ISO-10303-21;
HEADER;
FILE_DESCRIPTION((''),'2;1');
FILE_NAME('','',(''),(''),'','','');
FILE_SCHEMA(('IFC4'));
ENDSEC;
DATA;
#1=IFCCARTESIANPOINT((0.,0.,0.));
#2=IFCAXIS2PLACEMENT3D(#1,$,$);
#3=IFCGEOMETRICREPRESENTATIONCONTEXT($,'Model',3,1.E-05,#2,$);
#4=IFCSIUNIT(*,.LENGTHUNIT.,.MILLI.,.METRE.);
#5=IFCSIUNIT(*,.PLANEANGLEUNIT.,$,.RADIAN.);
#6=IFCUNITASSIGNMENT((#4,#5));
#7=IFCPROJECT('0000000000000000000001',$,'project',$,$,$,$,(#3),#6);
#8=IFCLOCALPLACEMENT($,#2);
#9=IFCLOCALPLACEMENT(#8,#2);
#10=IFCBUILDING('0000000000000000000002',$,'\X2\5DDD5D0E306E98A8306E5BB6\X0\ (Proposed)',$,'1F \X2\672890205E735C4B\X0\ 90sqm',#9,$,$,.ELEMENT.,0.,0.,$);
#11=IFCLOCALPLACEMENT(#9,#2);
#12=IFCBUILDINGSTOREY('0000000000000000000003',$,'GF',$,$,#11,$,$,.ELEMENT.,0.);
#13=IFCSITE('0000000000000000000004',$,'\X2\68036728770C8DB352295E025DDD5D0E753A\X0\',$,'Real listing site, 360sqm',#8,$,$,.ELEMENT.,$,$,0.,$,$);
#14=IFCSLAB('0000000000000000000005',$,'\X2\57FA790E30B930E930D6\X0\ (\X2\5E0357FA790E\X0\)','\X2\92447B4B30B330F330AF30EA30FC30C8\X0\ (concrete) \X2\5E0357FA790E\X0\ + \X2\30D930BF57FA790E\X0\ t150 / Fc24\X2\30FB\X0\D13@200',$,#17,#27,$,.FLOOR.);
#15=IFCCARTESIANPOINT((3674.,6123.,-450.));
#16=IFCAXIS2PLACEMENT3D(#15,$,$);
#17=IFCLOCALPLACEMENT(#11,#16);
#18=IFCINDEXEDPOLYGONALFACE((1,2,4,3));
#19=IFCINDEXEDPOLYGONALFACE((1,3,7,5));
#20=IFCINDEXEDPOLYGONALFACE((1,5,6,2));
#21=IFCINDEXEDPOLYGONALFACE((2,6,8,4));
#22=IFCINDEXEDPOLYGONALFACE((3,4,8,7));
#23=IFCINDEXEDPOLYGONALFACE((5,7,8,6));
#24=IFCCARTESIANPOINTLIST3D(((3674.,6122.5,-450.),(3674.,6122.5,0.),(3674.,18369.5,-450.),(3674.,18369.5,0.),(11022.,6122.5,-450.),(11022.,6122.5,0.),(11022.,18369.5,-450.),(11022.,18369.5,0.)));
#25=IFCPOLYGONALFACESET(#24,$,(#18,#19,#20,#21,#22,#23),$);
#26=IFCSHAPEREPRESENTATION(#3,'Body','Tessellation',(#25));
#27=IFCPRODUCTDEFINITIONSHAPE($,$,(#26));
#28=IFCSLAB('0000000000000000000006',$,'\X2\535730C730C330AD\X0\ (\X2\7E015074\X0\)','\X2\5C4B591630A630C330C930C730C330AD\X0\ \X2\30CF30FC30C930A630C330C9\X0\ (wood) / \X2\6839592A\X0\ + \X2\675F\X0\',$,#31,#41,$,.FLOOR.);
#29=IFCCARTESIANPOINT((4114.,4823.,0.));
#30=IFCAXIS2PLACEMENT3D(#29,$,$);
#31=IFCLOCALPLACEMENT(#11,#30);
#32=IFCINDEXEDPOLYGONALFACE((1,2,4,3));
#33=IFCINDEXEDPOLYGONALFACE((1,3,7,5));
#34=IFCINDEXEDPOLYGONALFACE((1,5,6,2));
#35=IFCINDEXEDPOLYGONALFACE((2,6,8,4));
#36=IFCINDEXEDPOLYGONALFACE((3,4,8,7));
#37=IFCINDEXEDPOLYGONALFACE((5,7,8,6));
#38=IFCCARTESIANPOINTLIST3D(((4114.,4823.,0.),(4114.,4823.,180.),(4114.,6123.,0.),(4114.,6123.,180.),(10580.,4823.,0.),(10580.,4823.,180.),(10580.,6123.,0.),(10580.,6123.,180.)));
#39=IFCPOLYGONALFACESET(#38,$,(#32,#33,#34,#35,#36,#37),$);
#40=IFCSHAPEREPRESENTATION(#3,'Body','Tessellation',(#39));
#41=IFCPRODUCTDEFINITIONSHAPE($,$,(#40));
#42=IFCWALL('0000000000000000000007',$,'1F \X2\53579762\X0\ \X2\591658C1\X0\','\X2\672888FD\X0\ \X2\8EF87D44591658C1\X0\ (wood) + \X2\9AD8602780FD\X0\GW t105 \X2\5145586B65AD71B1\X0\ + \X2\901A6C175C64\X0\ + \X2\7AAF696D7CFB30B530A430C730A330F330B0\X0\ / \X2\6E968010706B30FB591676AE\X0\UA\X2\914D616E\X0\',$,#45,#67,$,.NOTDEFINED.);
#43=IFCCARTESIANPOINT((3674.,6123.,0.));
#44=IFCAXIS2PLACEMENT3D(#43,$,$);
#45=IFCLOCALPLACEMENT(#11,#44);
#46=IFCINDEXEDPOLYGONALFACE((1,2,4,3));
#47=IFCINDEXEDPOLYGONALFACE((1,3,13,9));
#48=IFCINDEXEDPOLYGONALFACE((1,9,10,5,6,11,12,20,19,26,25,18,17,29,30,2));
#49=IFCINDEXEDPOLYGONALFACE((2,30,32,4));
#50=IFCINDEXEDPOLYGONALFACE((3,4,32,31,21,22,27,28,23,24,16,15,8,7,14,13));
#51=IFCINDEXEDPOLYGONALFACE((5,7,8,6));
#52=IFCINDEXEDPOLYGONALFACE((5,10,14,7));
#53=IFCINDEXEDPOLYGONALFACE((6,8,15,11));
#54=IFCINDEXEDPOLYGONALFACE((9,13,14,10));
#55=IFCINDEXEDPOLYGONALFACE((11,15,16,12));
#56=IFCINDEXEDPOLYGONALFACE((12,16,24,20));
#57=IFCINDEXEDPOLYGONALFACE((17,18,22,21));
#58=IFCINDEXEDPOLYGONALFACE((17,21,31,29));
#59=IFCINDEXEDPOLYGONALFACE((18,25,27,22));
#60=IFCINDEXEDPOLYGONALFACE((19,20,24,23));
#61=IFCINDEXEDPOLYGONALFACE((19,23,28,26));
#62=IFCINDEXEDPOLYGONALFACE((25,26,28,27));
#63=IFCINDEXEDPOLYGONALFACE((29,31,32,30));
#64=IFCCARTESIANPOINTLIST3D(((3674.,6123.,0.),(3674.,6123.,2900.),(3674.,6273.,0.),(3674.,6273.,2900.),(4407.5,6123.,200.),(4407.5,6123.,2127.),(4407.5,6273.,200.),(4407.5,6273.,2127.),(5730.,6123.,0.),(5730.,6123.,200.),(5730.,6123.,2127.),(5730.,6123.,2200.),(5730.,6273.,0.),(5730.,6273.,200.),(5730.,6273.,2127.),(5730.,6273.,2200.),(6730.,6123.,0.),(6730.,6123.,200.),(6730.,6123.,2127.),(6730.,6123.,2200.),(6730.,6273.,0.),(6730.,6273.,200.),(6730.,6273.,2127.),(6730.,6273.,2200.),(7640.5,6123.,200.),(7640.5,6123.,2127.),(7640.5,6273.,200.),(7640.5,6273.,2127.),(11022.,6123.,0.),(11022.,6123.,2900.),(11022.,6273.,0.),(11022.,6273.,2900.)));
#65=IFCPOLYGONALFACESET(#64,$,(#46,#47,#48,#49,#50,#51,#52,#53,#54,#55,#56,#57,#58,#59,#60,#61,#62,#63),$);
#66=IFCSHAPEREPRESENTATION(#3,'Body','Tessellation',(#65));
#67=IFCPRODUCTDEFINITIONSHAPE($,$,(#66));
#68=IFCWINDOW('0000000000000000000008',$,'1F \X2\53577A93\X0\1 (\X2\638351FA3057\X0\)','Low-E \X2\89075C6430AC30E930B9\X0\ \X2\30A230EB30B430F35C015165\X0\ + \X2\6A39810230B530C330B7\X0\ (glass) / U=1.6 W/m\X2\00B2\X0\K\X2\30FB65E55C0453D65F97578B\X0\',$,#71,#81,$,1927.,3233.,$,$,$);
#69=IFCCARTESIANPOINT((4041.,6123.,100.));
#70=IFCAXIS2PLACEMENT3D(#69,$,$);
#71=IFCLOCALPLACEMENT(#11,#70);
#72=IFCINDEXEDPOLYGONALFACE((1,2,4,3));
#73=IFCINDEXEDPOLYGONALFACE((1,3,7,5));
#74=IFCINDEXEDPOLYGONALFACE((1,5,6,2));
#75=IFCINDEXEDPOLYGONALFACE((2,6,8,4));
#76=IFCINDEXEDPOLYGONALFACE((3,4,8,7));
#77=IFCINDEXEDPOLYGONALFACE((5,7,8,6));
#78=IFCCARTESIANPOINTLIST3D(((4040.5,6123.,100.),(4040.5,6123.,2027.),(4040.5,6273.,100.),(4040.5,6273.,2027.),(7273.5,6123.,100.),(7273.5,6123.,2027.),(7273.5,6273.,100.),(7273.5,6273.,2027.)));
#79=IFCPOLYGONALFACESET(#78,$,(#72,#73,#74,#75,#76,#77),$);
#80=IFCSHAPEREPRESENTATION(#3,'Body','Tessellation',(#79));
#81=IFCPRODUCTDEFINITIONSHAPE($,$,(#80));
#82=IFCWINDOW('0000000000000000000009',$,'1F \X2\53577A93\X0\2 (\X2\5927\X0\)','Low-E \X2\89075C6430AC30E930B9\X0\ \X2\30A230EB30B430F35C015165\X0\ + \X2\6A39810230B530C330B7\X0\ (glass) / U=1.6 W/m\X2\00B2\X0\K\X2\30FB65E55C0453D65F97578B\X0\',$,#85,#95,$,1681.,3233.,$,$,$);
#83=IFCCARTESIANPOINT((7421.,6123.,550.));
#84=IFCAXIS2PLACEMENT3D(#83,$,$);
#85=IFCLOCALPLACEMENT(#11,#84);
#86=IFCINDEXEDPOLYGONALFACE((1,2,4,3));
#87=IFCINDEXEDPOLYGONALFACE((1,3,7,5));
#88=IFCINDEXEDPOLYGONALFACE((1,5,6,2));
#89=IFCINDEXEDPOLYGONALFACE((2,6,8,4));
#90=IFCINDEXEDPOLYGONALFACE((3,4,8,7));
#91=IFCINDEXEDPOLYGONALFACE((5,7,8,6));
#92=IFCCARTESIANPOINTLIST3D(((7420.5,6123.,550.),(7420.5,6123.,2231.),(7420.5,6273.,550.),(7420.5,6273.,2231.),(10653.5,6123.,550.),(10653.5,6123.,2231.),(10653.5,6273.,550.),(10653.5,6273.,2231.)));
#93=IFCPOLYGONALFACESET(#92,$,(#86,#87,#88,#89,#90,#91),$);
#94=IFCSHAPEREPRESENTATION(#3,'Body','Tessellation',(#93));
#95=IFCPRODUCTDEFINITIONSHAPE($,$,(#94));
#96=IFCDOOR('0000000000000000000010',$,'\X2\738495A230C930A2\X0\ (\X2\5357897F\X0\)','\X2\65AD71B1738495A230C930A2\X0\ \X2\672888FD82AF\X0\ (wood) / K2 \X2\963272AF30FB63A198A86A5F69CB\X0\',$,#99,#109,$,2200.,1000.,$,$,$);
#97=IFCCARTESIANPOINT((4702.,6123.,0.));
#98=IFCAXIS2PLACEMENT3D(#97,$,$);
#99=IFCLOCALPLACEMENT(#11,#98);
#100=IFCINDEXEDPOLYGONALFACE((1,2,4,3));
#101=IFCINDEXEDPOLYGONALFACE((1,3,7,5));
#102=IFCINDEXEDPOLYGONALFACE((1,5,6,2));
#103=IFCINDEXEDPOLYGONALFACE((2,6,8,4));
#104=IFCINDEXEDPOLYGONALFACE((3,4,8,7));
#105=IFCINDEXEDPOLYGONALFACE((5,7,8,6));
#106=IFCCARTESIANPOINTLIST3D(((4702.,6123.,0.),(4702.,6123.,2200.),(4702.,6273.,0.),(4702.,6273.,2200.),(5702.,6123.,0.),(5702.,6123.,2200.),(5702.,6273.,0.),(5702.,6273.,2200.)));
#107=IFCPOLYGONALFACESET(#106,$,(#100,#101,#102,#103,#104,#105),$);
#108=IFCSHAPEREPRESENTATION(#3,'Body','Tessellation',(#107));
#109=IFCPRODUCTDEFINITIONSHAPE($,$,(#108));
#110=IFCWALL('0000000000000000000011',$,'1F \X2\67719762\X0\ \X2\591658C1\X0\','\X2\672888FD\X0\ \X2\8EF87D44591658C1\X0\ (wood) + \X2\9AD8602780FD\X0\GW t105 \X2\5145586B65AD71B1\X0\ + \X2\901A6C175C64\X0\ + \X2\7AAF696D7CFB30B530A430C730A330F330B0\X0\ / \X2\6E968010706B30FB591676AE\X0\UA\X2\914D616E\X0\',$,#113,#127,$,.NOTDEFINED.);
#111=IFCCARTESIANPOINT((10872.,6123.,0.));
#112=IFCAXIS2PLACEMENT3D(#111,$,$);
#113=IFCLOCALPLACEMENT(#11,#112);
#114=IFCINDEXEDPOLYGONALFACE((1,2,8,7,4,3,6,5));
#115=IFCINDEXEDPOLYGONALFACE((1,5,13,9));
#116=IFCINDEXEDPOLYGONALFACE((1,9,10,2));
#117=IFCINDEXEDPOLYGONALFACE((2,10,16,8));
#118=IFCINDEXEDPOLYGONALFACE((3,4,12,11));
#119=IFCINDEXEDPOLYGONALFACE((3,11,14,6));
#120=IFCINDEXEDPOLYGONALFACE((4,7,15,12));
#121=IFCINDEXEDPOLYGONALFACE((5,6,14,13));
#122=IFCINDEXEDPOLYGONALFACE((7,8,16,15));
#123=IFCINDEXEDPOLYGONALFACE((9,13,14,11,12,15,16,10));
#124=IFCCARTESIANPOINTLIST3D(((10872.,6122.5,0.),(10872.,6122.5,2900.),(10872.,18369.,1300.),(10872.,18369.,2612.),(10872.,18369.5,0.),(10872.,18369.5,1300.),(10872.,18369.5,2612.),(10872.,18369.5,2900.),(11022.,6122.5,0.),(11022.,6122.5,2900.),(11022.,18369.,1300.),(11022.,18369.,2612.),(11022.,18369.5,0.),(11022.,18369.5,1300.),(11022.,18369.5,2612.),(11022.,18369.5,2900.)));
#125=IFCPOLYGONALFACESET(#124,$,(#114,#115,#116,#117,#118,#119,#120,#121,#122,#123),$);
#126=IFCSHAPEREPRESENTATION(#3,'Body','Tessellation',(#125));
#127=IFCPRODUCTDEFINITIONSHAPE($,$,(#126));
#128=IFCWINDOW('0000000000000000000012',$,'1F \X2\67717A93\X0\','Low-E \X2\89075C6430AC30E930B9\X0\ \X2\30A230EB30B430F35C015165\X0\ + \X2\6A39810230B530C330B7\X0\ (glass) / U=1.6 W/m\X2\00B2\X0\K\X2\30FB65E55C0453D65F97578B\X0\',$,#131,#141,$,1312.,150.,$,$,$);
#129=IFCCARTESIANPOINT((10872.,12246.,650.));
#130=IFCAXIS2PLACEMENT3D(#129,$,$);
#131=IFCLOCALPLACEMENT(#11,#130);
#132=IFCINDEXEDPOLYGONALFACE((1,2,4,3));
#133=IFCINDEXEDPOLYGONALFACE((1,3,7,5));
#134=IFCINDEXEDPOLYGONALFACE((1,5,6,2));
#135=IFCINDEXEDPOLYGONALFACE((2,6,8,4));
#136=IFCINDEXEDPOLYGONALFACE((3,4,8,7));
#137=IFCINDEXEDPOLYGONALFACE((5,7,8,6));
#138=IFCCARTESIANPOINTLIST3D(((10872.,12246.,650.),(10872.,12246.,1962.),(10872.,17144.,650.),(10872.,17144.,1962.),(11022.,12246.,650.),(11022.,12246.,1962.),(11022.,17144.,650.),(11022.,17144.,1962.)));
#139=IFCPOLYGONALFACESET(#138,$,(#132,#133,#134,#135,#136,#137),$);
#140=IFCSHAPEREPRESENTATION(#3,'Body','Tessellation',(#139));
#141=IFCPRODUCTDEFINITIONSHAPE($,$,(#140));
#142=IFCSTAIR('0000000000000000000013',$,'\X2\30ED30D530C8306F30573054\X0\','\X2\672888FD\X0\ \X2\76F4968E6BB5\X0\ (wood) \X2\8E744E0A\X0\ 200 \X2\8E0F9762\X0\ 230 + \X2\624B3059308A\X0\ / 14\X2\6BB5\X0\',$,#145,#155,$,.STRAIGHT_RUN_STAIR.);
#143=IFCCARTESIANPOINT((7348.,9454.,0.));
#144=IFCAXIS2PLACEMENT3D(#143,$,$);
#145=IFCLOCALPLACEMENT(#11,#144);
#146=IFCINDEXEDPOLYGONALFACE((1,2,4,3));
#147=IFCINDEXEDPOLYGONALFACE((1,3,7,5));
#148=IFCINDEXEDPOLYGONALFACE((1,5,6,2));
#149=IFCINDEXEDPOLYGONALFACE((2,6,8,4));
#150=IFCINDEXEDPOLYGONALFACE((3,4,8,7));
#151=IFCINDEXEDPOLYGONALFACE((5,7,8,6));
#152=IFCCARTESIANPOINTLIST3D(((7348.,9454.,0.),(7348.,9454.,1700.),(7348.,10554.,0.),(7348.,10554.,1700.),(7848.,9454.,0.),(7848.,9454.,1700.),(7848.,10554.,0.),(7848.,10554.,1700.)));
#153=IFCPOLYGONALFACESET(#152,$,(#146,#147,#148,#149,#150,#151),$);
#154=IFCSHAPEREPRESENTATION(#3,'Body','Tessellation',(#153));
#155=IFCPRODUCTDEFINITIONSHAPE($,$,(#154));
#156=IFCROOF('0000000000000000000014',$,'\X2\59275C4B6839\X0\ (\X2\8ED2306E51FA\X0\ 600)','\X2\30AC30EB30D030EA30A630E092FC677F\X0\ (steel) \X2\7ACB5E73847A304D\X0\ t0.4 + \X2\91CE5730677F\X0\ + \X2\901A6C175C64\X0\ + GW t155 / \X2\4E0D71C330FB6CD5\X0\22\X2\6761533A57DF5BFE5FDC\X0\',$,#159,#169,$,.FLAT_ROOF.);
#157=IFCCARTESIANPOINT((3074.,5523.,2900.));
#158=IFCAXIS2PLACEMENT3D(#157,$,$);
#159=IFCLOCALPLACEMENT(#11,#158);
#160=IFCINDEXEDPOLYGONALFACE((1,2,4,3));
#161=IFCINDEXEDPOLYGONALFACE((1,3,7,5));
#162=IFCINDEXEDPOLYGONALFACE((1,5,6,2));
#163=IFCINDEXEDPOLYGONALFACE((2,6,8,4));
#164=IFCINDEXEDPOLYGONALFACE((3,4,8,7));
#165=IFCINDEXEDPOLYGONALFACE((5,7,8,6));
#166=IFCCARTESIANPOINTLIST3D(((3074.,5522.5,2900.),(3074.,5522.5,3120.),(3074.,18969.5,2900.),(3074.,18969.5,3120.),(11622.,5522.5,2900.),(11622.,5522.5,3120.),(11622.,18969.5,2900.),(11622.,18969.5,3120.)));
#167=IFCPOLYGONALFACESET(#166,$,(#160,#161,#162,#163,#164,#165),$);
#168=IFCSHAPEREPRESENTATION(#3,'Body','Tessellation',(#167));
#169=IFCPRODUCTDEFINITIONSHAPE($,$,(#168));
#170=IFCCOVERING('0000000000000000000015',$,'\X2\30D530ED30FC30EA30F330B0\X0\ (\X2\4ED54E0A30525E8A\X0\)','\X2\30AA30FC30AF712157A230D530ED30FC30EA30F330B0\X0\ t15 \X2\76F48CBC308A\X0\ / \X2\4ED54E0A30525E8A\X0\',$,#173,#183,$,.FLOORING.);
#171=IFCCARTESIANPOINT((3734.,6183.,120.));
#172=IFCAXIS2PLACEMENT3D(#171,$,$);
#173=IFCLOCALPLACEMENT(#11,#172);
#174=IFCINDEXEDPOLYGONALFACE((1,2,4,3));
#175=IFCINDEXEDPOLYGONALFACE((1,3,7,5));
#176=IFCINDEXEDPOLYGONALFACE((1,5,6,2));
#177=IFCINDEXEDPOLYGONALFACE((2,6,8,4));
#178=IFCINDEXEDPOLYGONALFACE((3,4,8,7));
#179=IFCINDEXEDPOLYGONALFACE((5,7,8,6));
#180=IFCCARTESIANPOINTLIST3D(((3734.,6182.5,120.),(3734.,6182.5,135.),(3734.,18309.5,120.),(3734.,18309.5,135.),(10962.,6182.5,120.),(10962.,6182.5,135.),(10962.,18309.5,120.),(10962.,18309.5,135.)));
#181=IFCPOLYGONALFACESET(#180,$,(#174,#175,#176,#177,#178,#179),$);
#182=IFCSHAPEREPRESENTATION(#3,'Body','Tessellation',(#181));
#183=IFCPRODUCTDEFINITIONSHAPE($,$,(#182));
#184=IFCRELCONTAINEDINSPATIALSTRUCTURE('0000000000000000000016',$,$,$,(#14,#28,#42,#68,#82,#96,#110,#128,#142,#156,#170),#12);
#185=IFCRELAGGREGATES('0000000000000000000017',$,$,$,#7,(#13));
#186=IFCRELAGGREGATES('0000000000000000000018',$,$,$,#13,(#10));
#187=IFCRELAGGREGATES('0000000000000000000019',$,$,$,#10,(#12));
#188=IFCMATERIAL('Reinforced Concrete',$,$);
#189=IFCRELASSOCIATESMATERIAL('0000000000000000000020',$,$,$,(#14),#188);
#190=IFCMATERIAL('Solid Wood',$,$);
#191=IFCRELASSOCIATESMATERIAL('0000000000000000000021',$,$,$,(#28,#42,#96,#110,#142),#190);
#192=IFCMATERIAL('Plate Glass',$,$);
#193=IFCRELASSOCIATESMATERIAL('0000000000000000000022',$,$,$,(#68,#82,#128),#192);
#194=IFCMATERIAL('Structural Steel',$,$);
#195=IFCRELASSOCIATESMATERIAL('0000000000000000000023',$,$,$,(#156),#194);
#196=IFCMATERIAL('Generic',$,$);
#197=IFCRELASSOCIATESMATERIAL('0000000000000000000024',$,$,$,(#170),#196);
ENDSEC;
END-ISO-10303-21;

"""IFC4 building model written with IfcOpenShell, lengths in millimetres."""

from ifc_helpers import new_model, si_unit, frame, frame_2d, origin, place, context, project, spatial, rectangle, extrude, material, element, fill, save


model = new_model("IFC4")

# Units and contexts
model_context = context("Model", 3, precision=1e-05, world=origin())
ifc_project = project(units=[si_unit("LENGTHUNIT", "METRE", prefix="MILLI"), si_unit("PLANEANGLEUNIT", "RADIAN")], contexts=[model_context])

# Site, building, storey
site_placement = place(None, origin())
site = spatial("IfcSite", under=ifc_project, at=site_placement, Name="栃木県足利市川崎町", ObjectType="Real listing site, 360sqm", CompositionType="ELEMENT", RefElevation=0.0)
building_placement = place(site_placement, origin())
building = spatial("IfcBuilding", under=site, at=building_placement, Name="川崎の風の家 (Proposed)", ObjectType="1F 木造平屋 90sqm", CompositionType="ELEMENT", ElevationOfRefHeight=0.0, ElevationOfTerrain=0.0)
storey_placement = place(building_placement, origin())
storey = spatial("IfcBuildingStorey", under=building, at=storey_placement, Name="GF", CompositionType="ELEMENT", Elevation=0.0)

# Slabs
ifc_material_1 = material(Name="Reinforced Concrete")
slab_1_placement = place(storey_placement, frame((3674.0, 6123.0, -450.0)))
element("IfcSlab", 1, at=slab_1_placement, inside=storey, material=ifc_material_1, Name="基礎スラブ (布基礎)", Description="鉄筋コンクリート (concrete) 布基礎 + ベタ基礎 t150 / Fc24・D13@200", PredefinedType="FLOOR", context=model_context, shape_type="SweptSolid", body=[
    extrude(rectangle(XDim=7348.0, YDim=12247.0, at=frame_2d((3674.0, 6123.0))), frame((3674.0, 6123.0, -450.0)), (0.0, 0.0, 1.0), 450.0),
])
ifc_material_2 = material(Name="Solid Wood")
slab_2_placement = place(storey_placement, frame((4114.0, 4823.0, 0.0)))
element("IfcSlab", 2, at=slab_2_placement, inside=storey, material=ifc_material_2, Name="南デッキ (縁側)", Description="屋外ウッドデッキ ハードウッド (wood) / 根太 + 束", PredefinedType="FLOOR", context=model_context, shape_type="SweptSolid", body=[
    extrude(rectangle(XDim=6466.0, YDim=1300.0, at=frame_2d((3233.0, 650.0))), frame((4114.0, 4823.0, 0.0)), (0.0, 0.0, 1.0), 180.0),
])

# Wall, openings, windows, door
wall_1_placement = place(storey_placement, frame((3674.0, 6123.0, 0.0)))
wall_1 = element("IfcWall", 3, at=wall_1_placement, inside=storey, material=ifc_material_2, Name="1F 南面 外壁", Description="木製 軸組外壁 (wood) + 高性能GW t105 充填断熱 + 通気層 + 窯業系サイディング / 準耐火・外皮UA配慮", PredefinedType="NOTDEFINED", context=model_context, shape_type="SweptSolid", body=[
    extrude(rectangle(XDim=7348.0, YDim=150.0, at=frame_2d((3674.0, 75.0))), frame((3674.0, 6123.0, 0.0)), (0.0, 0.0, 1.0), 2900.0),
])
opening_1_placement = place(storey_placement, frame((4041.0, 6123.0, 100.0)))
opening_1 = element("IfcOpeningElement", 4, at=opening_1_placement, cuts=wall_1, PredefinedType="NOTDEFINED", context=model_context, shape_type="SweptSolid", body=[
    extrude(rectangle(XDim=3233.0, YDim=150.0, at=frame_2d((1616.0, 75.0))), frame((4041.0, 6123.0, 100.0)), (0.0, 0.0, 1.0), 1927.0),
])
opening_2_placement = place(storey_placement, frame((7421.0, 6123.0, 550.0)))
opening_2 = element("IfcOpeningElement", 5, at=opening_2_placement, cuts=wall_1, PredefinedType="NOTDEFINED", context=model_context, shape_type="SweptSolid", body=[
    extrude(rectangle(XDim=3233.0, YDim=150.0, at=frame_2d((1616.0, 75.0))), frame((7421.0, 6123.0, 550.0)), (0.0, 0.0, 1.0), 1681.0),
])
opening_3_placement = place(storey_placement, frame((4702.0, 6123.0, 0.0)))
opening_3 = element("IfcOpeningElement", 6, at=opening_3_placement, cuts=wall_1, PredefinedType="NOTDEFINED", context=model_context, shape_type="SweptSolid", body=[
    extrude(rectangle(XDim=1000.0, YDim=150.0, at=frame_2d((500.0, 75.0))), frame((4702.0, 6123.0, 0.0)), (0.0, 0.0, 1.0), 2200.0),
])
ifc_material_3 = material(Name="Plate Glass")
window_1_placement = place(storey_placement, frame((4041.0, 6123.0, 100.0)))
window_1 = element("IfcWindow", 7, at=window_1_placement, inside=storey, material=ifc_material_3, Name="1F 南窓1 (掃出し)", Description="Low-E 複層ガラス アルゴン封入 + 樹脂サッシ (glass) / U=1.6 W/m²K・日射取得型", OverallHeight=1927.0, OverallWidth=3233.0, context=model_context, shape_type="SweptSolid", body=[
    extrude(rectangle(XDim=3233.0, YDim=150.0, at=frame_2d((1616.0, 75.0))), frame((4041.0, 6123.0, 100.0)), (0.0, 0.0, 1.0), 1927.0),
])
fill(opening_1, window_1)
window_2_placement = place(storey_placement, frame((7421.0, 6123.0, 550.0)))
window_2 = element("IfcWindow", 8, at=window_2_placement, inside=storey, material=ifc_material_3, Name="1F 南窓2 (大)", Description="Low-E 複層ガラス アルゴン封入 + 樹脂サッシ (glass) / U=1.6 W/m²K・日射取得型", OverallHeight=1681.0, OverallWidth=3233.0, context=model_context, shape_type="SweptSolid", body=[
    extrude(rectangle(XDim=3233.0, YDim=150.0, at=frame_2d((1616.0, 75.0))), frame((7421.0, 6123.0, 550.0)), (0.0, 0.0, 1.0), 1681.0),
])
fill(opening_2, window_2)
door_placement = place(storey_placement, frame((4702.0, 6123.0, 0.0)))
door = element("IfcDoor", 9, at=door_placement, inside=storey, material=ifc_material_2, Name="玄関ドア (南西)", Description="断熱玄関ドア 木製芯 (wood) / K2 防犯・採風機構", OverallHeight=2200.0, OverallWidth=1000.0, context=model_context, shape_type="SweptSolid", body=[
    extrude(rectangle(XDim=1000.0, YDim=150.0, at=frame_2d((500.0, 75.0))), frame((4702.0, 6123.0, 0.0)), (0.0, 0.0, 1.0), 2200.0),
])
fill(opening_3, door)

# Wall, opening, window
wall_2_placement = place(storey_placement, frame((10872.0, 6123.0, 0.0)))
wall_2 = element("IfcWall", 10, at=wall_2_placement, inside=storey, material=ifc_material_2, Name="1F 東面 外壁", Description="木製 軸組外壁 (wood) + 高性能GW t105 充填断熱 + 通気層 + 窯業系サイディング / 準耐火・外皮UA配慮", PredefinedType="NOTDEFINED", context=model_context, shape_type="SweptSolid", body=[
    extrude(rectangle(XDim=150.0, YDim=12247.0, at=frame_2d((75.0, 6123.0))), frame((10872.0, 6123.0, 0.0)), (0.0, 0.0, 1.0), 2900.0),
])
opening_4_placement = place(storey_placement, frame((10872.0, 12246.0, 650.0)))
opening_4 = element("IfcOpeningElement", 11, at=opening_4_placement, cuts=wall_2, PredefinedType="NOTDEFINED", context=model_context, shape_type="SweptSolid", body=[
    extrude(rectangle(XDim=150.0, YDim=4898.0, at=frame_2d((75.0, 2449.0))), frame((10872.0, 12246.0, 650.0)), (0.0, 0.0, 1.0), 1312.0),
])
window_3_placement = place(storey_placement, frame((10872.0, 12246.0, 650.0)))
window_3 = element("IfcWindow", 12, at=window_3_placement, inside=storey, material=ifc_material_3, Name="1F 東窓", Description="Low-E 複層ガラス アルゴン封入 + 樹脂サッシ (glass) / U=1.6 W/m²K・日射取得型", OverallHeight=1312.0, OverallWidth=150.0, context=model_context, shape_type="SweptSolid", body=[
    extrude(rectangle(XDim=150.0, YDim=4898.0, at=frame_2d((75.0, 2449.0))), frame((10872.0, 12246.0, 650.0)), (0.0, 0.0, 1.0), 1312.0),
])
fill(opening_4, window_3)

# Stair
stair_placement = place(storey_placement, frame((7348.0, 9454.0, 0.0)))
element("IfcStair", 13, at=stair_placement, inside=storey, material=ifc_material_2, Name="ロフトはしご", Description="木製 直階段 (wood) 蹴上 200 踏面 230 + 手すり / 14段", PredefinedType="STRAIGHT_RUN_STAIR", context=model_context, shape_type="SweptSolid", body=[
    extrude(rectangle(XDim=500.0, YDim=1100.0, at=frame_2d((250.0, 550.0))), frame((7348.0, 9454.0, 0.0)), (0.0, 0.0, 1.0), 1700.0),
])

# Roof
ifc_material_4 = material(Name="Structural Steel")
roof_placement = place(storey_placement, frame((3074.0, 5523.0, 2900.0)))
element("IfcRoof", 14, at=roof_placement, inside=storey, material=ifc_material_4, Name="大屋根 (軒の出 600)", Description="ガルバリウム鋼板 (steel) 立平葺き t0.4 + 野地板 + 通気層 + GW t155 / 不燃・法22条区域対応", PredefinedType="FLAT_ROOF", context=model_context, shape_type="SweptSolid", body=[
    extrude(rectangle(XDim=8548.0, YDim=13447.0, at=frame_2d((4274.0, 6723.0))), frame((3074.0, 5523.0, 2900.0)), (0.0, 0.0, 1.0), 220.0),
])

# Covering
ifc_material_5 = material(Name="Generic")
covering_placement = place(storey_placement, frame((3734.0, 6183.0, 120.0)))
element("IfcCovering", 15, at=covering_placement, inside=storey, material=ifc_material_5, Name="フローリング (仕上げ床)", Description="オーク無垢フローリング t15 直貼り / 仕上げ床", PredefinedType="FLOORING", context=model_context, shape_type="SweptSolid", body=[
    extrude(rectangle(XDim=7228.0, YDim=12127.0, at=frame_2d((3614.0, 6063.0))), frame((3734.0, 6183.0, 120.0)), (0.0, 0.0, 1.0), 15.0),
])

save(model, "model.ifc")
